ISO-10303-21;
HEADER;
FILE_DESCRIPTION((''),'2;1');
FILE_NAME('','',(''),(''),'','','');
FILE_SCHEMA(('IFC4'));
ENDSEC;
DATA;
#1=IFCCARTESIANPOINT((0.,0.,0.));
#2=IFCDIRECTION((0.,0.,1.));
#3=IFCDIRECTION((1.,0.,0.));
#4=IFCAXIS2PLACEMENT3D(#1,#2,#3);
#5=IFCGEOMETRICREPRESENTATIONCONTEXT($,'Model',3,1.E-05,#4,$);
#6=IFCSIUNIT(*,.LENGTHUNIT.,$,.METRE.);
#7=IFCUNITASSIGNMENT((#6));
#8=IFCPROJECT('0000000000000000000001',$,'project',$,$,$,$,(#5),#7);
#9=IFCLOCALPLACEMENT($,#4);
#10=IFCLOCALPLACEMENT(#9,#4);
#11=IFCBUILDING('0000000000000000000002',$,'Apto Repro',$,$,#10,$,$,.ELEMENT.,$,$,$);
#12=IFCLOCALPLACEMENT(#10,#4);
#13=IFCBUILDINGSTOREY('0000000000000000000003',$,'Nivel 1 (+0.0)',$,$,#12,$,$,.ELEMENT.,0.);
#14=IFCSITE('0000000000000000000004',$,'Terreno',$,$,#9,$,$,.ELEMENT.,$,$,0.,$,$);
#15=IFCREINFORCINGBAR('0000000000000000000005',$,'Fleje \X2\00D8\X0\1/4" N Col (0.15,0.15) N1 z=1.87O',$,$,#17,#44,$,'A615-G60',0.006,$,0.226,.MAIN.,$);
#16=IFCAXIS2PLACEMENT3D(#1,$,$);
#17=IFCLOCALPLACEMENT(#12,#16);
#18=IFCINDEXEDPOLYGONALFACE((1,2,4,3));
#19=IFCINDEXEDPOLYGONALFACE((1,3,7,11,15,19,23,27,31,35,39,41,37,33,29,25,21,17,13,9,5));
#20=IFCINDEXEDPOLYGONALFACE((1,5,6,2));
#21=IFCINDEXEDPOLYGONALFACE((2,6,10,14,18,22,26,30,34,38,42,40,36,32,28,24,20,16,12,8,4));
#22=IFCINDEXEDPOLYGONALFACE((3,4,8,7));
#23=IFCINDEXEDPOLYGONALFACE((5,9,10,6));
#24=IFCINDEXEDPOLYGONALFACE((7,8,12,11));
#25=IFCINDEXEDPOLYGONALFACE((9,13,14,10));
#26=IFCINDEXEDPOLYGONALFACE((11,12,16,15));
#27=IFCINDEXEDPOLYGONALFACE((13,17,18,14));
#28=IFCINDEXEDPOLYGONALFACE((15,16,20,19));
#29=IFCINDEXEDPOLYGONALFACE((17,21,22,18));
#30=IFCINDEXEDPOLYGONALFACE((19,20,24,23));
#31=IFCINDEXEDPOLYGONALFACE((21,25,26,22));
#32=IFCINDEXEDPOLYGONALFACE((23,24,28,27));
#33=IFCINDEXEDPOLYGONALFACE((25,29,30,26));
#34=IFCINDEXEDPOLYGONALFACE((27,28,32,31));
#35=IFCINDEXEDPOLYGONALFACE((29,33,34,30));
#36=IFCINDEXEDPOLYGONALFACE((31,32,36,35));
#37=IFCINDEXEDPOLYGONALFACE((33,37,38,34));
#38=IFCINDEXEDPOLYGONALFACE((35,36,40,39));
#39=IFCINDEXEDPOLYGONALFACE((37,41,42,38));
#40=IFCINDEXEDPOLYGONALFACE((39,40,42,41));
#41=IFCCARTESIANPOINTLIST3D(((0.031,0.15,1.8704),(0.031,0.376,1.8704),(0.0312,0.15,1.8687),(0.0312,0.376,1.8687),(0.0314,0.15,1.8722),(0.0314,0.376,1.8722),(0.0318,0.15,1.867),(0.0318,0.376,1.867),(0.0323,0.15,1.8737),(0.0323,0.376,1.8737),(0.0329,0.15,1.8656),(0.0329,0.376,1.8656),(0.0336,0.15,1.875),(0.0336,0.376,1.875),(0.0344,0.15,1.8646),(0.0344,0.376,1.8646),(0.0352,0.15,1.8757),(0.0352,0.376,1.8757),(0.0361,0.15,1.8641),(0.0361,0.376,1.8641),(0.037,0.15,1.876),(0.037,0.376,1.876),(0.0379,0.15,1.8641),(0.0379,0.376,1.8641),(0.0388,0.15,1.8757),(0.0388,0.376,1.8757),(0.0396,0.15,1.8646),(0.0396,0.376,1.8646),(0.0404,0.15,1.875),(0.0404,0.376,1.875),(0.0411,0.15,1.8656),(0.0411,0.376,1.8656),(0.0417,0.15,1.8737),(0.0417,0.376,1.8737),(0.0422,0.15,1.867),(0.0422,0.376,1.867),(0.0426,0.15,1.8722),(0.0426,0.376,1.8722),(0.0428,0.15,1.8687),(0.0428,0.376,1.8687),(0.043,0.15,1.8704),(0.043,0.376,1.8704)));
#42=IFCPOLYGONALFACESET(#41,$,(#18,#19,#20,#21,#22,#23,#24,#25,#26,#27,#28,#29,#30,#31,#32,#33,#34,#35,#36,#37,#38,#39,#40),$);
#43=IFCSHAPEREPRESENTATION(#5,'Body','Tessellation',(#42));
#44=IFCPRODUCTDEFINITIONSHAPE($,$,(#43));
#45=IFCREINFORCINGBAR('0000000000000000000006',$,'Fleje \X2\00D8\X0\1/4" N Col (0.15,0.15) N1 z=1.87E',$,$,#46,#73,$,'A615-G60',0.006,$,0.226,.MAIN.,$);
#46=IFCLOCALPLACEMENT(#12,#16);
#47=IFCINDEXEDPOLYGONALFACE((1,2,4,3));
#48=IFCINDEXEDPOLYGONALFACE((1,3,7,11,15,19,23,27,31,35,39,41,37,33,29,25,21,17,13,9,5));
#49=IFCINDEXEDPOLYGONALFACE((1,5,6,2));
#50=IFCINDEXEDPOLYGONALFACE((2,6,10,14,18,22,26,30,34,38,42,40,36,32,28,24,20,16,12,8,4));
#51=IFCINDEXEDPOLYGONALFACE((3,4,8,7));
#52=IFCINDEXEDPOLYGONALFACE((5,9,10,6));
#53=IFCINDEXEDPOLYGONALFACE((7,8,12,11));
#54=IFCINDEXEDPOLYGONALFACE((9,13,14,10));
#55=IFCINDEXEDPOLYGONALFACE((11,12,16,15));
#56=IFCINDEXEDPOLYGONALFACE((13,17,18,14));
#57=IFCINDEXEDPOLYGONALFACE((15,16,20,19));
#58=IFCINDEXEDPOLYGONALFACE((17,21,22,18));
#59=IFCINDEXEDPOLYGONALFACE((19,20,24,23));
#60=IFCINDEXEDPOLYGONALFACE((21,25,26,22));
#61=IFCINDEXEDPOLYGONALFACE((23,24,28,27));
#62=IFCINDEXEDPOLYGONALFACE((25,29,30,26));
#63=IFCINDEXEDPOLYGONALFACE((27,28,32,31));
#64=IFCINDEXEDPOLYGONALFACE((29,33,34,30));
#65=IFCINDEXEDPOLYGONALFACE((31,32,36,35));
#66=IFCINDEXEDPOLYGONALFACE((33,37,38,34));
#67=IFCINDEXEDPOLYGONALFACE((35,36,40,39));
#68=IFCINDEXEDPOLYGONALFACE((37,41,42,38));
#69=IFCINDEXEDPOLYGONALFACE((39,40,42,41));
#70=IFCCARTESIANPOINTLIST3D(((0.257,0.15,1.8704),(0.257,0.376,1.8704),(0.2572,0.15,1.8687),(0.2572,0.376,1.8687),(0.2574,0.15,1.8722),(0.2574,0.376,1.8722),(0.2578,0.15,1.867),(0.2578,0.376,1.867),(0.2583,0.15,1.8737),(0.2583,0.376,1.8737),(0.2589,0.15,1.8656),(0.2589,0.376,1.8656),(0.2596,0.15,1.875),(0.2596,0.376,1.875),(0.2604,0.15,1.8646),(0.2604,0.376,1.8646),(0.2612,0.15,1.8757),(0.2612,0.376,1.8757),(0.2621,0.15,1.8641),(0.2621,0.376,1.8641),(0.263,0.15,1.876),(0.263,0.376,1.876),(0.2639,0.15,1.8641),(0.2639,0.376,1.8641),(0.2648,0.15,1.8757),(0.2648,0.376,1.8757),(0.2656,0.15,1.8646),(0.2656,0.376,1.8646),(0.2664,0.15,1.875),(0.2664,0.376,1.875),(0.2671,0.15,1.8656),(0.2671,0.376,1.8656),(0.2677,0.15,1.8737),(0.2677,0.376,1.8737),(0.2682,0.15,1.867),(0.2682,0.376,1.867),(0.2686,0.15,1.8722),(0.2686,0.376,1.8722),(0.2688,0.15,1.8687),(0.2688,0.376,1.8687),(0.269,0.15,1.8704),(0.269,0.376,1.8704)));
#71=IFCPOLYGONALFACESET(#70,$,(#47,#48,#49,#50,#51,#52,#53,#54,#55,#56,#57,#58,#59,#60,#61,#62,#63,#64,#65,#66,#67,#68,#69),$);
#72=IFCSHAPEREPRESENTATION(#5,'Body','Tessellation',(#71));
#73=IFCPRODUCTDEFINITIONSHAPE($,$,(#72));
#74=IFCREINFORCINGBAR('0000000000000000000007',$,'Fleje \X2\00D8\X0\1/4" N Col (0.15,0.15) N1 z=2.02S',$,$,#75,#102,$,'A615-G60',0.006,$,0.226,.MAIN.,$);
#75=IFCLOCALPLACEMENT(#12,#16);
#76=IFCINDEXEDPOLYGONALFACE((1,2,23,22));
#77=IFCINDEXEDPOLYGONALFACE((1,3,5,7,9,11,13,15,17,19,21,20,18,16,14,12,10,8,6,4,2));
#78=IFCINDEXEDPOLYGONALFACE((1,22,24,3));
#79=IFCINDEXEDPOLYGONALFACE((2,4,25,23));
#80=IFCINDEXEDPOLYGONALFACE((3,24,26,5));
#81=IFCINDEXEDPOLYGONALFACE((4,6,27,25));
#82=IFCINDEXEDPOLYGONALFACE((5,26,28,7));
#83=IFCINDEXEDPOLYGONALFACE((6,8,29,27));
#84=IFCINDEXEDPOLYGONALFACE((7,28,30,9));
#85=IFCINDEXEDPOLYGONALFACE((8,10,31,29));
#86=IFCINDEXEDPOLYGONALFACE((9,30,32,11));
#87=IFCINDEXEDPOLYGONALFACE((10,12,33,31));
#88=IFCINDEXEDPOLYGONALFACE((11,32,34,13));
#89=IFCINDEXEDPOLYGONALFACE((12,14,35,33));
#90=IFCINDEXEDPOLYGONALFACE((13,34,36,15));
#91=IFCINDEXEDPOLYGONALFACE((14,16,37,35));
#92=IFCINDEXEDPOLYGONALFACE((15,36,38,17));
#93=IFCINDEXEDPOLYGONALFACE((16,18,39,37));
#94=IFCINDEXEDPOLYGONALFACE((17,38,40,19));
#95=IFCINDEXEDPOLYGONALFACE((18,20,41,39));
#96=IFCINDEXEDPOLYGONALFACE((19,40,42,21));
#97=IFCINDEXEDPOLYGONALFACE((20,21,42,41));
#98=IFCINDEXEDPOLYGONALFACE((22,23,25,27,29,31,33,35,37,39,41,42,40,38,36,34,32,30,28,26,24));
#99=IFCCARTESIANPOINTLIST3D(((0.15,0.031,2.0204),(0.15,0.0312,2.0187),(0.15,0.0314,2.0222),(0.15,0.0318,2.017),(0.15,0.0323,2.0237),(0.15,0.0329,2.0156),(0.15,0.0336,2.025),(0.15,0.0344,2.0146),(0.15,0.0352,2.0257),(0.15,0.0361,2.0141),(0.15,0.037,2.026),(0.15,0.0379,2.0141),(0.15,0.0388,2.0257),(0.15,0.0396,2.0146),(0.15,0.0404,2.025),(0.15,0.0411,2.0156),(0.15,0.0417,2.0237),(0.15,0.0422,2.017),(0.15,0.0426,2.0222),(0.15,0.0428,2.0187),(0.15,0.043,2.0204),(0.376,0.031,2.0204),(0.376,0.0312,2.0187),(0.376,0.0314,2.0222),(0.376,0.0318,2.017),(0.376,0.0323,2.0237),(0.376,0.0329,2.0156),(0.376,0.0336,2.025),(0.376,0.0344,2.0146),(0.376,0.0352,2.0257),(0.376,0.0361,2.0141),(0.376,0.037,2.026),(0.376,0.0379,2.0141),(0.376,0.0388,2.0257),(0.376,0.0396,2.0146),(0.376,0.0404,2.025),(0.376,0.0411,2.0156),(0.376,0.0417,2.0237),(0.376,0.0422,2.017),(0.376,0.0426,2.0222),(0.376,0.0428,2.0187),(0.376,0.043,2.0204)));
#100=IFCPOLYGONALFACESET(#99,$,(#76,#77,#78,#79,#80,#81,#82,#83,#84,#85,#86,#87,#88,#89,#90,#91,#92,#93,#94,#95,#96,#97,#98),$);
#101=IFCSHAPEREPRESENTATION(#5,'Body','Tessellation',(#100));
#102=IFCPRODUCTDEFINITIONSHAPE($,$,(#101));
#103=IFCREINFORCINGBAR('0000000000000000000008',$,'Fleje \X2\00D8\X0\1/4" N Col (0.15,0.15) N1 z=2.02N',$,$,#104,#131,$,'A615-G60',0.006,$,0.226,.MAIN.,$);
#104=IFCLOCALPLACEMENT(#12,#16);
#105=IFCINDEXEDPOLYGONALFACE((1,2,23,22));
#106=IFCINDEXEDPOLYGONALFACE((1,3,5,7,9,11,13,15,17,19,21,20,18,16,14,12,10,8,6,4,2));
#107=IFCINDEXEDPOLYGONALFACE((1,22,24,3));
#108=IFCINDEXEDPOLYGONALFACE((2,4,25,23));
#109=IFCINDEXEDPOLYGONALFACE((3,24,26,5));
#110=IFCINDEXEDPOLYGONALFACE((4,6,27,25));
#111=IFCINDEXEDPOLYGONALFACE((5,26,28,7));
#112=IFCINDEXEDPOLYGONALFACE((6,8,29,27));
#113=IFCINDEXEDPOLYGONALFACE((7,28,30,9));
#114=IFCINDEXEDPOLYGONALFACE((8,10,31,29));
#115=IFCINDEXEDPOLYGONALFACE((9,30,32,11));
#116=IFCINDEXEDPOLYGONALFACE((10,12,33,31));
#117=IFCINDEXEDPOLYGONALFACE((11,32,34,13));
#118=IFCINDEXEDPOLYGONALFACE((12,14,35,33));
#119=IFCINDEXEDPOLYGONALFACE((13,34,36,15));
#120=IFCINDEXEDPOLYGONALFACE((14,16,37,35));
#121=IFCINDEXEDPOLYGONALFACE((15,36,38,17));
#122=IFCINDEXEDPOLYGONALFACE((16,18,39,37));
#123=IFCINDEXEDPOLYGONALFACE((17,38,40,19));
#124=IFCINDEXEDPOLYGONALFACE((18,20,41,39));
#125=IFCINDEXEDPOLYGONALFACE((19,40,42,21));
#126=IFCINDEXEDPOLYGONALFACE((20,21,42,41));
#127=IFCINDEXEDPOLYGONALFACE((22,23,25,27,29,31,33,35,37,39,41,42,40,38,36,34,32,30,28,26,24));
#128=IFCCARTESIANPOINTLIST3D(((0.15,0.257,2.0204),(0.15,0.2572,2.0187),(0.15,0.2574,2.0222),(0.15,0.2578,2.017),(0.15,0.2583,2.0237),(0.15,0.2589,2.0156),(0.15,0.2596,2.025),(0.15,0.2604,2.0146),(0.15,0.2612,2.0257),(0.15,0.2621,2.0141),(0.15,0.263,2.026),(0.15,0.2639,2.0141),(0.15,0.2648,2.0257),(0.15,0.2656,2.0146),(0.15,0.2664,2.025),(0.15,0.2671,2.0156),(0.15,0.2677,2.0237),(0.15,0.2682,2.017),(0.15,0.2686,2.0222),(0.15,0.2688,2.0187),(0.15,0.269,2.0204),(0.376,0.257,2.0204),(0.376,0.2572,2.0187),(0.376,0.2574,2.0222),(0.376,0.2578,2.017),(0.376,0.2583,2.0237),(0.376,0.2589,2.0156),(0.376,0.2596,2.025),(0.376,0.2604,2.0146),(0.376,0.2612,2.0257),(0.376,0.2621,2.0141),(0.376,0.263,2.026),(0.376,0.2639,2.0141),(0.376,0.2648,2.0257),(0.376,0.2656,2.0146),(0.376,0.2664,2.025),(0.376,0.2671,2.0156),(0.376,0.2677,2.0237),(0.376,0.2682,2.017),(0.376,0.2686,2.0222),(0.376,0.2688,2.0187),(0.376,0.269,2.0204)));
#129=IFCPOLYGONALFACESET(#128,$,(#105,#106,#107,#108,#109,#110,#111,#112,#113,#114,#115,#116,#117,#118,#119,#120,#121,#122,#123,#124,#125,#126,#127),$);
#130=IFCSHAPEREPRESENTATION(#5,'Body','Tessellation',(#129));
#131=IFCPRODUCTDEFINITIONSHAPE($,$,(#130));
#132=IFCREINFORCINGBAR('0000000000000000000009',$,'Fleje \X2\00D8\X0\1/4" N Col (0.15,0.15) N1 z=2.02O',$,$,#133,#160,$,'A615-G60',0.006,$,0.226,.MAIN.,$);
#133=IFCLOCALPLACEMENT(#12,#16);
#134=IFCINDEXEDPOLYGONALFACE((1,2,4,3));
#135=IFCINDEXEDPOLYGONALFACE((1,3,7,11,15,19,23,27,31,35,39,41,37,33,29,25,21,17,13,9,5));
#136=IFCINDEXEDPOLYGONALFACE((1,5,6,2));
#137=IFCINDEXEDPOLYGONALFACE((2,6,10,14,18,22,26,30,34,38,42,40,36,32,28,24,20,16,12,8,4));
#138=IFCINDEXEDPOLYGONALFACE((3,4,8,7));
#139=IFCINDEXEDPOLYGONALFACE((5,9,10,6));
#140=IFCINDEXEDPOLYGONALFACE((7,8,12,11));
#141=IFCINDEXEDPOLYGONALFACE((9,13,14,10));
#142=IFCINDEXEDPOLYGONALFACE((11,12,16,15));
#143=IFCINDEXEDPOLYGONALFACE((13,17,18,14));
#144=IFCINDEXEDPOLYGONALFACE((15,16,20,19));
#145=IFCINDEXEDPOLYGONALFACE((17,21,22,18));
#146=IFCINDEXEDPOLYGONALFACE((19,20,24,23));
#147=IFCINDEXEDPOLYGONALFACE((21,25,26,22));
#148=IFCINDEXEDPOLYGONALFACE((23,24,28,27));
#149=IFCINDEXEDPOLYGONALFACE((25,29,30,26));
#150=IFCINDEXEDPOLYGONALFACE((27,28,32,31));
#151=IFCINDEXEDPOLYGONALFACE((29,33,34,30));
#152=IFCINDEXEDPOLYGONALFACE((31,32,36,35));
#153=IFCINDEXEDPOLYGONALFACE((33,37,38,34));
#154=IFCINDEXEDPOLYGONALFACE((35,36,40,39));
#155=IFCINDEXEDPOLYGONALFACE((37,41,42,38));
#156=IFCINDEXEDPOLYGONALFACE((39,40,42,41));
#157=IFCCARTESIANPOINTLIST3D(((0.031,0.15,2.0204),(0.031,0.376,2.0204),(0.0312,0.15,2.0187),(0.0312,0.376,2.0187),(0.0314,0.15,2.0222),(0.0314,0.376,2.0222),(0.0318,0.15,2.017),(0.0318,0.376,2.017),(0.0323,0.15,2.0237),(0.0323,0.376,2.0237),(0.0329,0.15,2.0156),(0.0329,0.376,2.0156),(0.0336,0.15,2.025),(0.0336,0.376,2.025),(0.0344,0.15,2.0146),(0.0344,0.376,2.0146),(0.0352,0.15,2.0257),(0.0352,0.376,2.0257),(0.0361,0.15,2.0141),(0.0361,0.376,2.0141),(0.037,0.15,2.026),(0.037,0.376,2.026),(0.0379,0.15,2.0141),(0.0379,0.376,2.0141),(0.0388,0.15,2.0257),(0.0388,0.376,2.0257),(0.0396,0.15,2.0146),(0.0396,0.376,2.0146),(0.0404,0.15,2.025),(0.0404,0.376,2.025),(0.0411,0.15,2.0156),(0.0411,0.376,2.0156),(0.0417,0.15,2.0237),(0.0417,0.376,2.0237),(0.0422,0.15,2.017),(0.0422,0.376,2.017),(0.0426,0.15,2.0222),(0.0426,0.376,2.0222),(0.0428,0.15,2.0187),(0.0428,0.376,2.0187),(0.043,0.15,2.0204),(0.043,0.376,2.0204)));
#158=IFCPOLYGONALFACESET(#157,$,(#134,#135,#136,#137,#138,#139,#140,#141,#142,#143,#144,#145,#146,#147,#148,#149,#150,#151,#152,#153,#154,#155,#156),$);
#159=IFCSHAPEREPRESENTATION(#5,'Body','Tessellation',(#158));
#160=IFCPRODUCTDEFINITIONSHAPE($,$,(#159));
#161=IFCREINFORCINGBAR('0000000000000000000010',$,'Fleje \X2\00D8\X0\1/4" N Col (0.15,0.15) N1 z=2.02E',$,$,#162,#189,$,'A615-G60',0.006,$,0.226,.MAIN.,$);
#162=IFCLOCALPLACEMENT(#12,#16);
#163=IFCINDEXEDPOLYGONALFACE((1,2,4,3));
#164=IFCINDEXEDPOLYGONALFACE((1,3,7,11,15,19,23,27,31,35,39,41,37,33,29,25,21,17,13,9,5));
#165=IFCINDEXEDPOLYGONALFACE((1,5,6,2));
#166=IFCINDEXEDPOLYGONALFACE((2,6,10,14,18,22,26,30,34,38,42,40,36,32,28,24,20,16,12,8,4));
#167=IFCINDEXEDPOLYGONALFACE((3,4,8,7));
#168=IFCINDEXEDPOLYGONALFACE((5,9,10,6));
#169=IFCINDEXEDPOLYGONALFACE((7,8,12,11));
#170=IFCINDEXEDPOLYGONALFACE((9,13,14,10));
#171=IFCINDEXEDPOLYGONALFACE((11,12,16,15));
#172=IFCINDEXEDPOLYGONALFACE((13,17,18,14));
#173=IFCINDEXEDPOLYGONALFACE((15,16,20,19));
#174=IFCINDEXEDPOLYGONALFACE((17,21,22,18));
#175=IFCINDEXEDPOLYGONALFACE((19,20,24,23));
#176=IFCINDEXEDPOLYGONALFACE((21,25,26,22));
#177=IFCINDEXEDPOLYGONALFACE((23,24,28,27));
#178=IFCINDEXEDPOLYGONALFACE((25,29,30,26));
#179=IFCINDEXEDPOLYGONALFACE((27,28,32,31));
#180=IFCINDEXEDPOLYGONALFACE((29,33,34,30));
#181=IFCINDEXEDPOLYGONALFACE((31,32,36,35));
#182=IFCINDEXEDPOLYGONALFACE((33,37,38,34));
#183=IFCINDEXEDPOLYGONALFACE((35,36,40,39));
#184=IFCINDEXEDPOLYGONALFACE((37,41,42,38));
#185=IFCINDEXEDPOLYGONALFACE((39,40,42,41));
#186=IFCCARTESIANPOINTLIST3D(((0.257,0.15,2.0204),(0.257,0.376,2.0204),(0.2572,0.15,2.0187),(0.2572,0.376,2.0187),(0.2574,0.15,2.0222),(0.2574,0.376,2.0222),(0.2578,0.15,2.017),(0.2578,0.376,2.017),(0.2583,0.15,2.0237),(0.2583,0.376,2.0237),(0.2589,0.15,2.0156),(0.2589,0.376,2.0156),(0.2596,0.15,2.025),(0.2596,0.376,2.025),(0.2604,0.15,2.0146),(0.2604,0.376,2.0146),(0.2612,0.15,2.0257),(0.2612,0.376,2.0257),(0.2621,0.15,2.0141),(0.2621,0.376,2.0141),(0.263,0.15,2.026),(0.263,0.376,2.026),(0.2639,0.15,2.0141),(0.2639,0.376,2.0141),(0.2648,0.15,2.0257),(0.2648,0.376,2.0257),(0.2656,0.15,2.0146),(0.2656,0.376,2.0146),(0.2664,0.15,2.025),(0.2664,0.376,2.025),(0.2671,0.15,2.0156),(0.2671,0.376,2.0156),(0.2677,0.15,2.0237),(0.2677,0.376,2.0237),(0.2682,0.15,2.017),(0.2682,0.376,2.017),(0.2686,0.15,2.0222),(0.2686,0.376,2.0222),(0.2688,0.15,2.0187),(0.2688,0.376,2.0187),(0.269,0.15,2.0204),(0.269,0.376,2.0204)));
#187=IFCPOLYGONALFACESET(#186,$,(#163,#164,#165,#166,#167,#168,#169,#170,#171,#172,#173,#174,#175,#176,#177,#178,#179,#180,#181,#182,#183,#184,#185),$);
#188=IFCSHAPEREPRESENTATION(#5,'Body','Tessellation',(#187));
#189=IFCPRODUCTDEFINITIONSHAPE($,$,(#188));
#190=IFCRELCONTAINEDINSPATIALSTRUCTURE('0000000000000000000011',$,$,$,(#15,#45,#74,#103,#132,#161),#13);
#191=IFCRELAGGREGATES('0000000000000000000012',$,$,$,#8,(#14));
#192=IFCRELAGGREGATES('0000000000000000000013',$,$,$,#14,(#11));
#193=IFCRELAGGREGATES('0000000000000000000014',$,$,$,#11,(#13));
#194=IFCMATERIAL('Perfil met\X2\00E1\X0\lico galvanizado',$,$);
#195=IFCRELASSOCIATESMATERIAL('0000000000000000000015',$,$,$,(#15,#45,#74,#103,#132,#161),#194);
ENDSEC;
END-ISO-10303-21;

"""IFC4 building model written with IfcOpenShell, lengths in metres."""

from ifc_helpers import new_model, si_unit, frame, origin_with_axes, origin_2d_with_axis, place, context, project, spatial, circle, extrude, material, element, save


model = new_model("IFC4")

# Units and contexts
model_context = context("Model", 3, precision=1e-05, world=origin_with_axes())
ifc_project = project(units=[si_unit("LENGTHUNIT", "METRE")], contexts=[model_context])

# Site, building, storey
site_placement = place(None, origin_with_axes())
site = spatial("IfcSite", under=ifc_project, at=site_placement, Name="Terreno", CompositionType="ELEMENT", RefElevation=0.0)
building_placement = place(site_placement, origin_with_axes())
building = spatial("IfcBuilding", under=site, at=building_placement, Name="Apto Repro", CompositionType="ELEMENT")
storey_placement = place(building_placement, origin_with_axes())
storey = spatial("IfcBuildingStorey", under=building, at=storey_placement, Name="Nivel 1 (+0.0)", CompositionType="ELEMENT", Elevation=0.0)

# Reinforcing bars
ifc_material = material(Name="Perfil metálico galvanizado")
reinforcing_bar_1_placement = place(storey_placement, origin_with_axes())
element("IfcReinforcingBar", 1, at=reinforcing_bar_1_placement, inside=storey, material=ifc_material, Name="Fleje Ø1/4\" N Col (0.15,0.15) N1 z=1.87O", SteelGrade="A615-G60", BarLength=0.226, NominalDiameter=0.006, PredefinedType="MAIN", context=model_context, shape_type="SweptSolid", body=[
    extrude(circle(Radius=0.006, at=origin_2d_with_axis()), frame((0.037, 0.15, 1.87), z_axis=(0.0, 1.0, 0.0), x_axis=(0.0, 0.0, 1.0)), (0.0, 0.0, 1.0), 0.226),
])
reinforcing_bar_2_placement = place(storey_placement, origin_with_axes())
element("IfcReinforcingBar", 2, at=reinforcing_bar_2_placement, inside=storey, material=ifc_material, Name="Fleje Ø1/4\" N Col (0.15,0.15) N1 z=1.87E", SteelGrade="A615-G60", BarLength=0.226, NominalDiameter=0.006, PredefinedType="MAIN", context=model_context, shape_type="SweptSolid", body=[
    extrude(circle(Radius=0.006, at=origin_2d_with_axis()), frame((0.263, 0.15, 1.87), z_axis=(0.0, 1.0, 0.0), x_axis=(0.0, 0.0, 1.0)), (0.0, 0.0, 1.0), 0.226),
])
reinforcing_bar_3_placement = place(storey_placement, origin_with_axes())
element("IfcReinforcingBar", 3, at=reinforcing_bar_3_placement, inside=storey, material=ifc_material, Name="Fleje Ø1/4\" N Col (0.15,0.15) N1 z=2.02S", SteelGrade="A615-G60", BarLength=0.226, NominalDiameter=0.006, PredefinedType="MAIN", context=model_context, shape_type="SweptSolid", body=[
    extrude(circle(Radius=0.006, at=origin_2d_with_axis()), frame((0.15, 0.037, 2.02), z_axis=(1.0, 0.0, 0.0), x_axis=(0.0, 0.0, 1.0)), (0.0, 0.0, 1.0), 0.226),
])
reinforcing_bar_4_placement = place(storey_placement, origin_with_axes())
element("IfcReinforcingBar", 4, at=reinforcing_bar_4_placement, inside=storey, material=ifc_material, Name="Fleje Ø1/4\" N Col (0.15,0.15) N1 z=2.02N", SteelGrade="A615-G60", BarLength=0.226, NominalDiameter=0.006, PredefinedType="MAIN", context=model_context, shape_type="SweptSolid", body=[
    extrude(circle(Radius=0.006, at=origin_2d_with_axis()), frame((0.15, 0.263, 2.02), z_axis=(1.0, 0.0, 0.0), x_axis=(0.0, 0.0, 1.0)), (0.0, 0.0, 1.0), 0.226),
])
reinforcing_bar_5_placement = place(storey_placement, origin_with_axes())
element("IfcReinforcingBar", 5, at=reinforcing_bar_5_placement, inside=storey, material=ifc_material, Name="Fleje Ø1/4\" N Col (0.15,0.15) N1 z=2.02O", SteelGrade="A615-G60", BarLength=0.226, NominalDiameter=0.006, PredefinedType="MAIN", context=model_context, shape_type="SweptSolid", body=[
    extrude(circle(Radius=0.006, at=origin_2d_with_axis()), frame((0.037, 0.15, 2.02), z_axis=(0.0, 1.0, 0.0), x_axis=(0.0, 0.0, 1.0)), (0.0, 0.0, 1.0), 0.226),
])
reinforcing_bar_6_placement = place(storey_placement, origin_with_axes())
element("IfcReinforcingBar", 6, at=reinforcing_bar_6_placement, inside=storey, material=ifc_material, Name="Fleje Ø1/4\" N Col (0.15,0.15) N1 z=2.02E", SteelGrade="A615-G60", BarLength=0.226, NominalDiameter=0.006, PredefinedType="MAIN", context=model_context, shape_type="SweptSolid", body=[
    extrude(circle(Radius=0.006, at=origin_2d_with_axis()), frame((0.263, 0.15, 2.02), z_axis=(0.0, 1.0, 0.0), x_axis=(0.0, 0.0, 1.0)), (0.0, 0.0, 1.0), 0.226),
])

save(model, "model.ifc")
